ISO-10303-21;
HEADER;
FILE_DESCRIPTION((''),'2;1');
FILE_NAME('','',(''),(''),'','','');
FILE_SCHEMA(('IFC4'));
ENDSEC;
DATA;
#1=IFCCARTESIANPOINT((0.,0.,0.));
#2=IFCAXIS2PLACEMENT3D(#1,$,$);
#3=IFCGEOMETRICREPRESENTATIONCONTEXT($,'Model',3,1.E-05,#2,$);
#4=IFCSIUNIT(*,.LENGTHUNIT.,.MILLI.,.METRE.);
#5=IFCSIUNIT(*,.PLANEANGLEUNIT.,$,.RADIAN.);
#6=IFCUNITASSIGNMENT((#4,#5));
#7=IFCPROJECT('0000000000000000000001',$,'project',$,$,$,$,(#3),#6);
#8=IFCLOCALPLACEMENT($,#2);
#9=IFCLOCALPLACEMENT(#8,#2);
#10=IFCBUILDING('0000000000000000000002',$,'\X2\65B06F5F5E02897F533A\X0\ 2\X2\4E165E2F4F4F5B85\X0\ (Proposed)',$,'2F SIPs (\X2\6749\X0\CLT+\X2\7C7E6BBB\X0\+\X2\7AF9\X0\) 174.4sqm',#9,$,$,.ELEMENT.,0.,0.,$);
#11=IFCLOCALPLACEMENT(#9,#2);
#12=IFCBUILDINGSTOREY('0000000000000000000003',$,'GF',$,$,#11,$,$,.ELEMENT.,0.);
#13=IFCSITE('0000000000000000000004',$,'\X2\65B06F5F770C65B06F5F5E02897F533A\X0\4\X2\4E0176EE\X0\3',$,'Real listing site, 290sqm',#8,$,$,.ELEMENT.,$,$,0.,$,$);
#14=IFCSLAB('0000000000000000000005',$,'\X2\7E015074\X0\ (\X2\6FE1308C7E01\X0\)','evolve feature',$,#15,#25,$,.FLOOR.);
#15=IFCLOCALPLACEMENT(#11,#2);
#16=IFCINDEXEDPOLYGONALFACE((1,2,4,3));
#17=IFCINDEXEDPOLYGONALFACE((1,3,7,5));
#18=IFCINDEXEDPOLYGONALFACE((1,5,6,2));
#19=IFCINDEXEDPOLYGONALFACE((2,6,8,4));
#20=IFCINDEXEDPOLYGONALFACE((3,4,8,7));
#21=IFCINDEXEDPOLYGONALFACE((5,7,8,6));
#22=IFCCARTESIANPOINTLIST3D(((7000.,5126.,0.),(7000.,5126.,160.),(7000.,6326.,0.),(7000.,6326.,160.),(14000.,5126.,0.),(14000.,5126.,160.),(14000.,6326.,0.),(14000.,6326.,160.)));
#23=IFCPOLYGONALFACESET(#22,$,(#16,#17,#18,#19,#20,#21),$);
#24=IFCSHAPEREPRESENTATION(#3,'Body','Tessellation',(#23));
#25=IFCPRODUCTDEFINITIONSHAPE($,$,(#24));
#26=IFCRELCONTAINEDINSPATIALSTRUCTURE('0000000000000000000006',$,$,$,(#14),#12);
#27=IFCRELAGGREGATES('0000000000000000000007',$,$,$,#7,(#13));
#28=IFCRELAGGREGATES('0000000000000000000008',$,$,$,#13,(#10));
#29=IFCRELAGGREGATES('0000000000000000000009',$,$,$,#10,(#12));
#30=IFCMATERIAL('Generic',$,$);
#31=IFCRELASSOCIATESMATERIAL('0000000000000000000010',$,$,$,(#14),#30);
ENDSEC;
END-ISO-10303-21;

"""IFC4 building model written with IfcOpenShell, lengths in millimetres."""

from ifc_helpers import new_model, si_unit, frame, frame_2d, origin, place, context, project, spatial, rectangle, extrude, material, element, save


model = new_model("IFC4")

# Units and contexts
model_context = context("Model", 3, precision=1e-05, world=origin())
ifc_project = project(units=[si_unit("LENGTHUNIT", "METRE", prefix="MILLI"), si_unit("PLANEANGLEUNIT", "RADIAN")], contexts=[model_context])

# Site, building, storey
site_placement = place(None, origin())
site = spatial("IfcSite", under=ifc_project, at=site_placement, Name="新潟県新潟市西区4丁目3", ObjectType="Real listing site, 290sqm", CompositionType="ELEMENT", RefElevation=0.0)
building_placement = place(site_placement, origin())
building = spatial("IfcBuilding", under=site, at=building_placement, Name="新潟市西区 2世帯住宅 (Proposed)", ObjectType="2F SIPs (杉CLT+籾殻+竹) 174.4sqm", CompositionType="ELEMENT", ElevationOfRefHeight=0.0, ElevationOfTerrain=0.0)
storey_placement = place(building_placement, origin())
storey = spatial("IfcBuildingStorey", under=building, at=storey_placement, Name="GF", CompositionType="ELEMENT", Elevation=0.0)

# Slab
ifc_material_1 = material(Name="Generic")
slab_1_placement = place(storey_placement, frame((3500.0, 2563.0, 0.0)))
element("IfcSlab", 1, at=slab_1_placement, inside=storey, material=ifc_material_1, Name="縁側 (濡れ縁)", Description="evolve feature", PredefinedType="FLOOR", context=model_context, shape_type="SweptSolid", body=[
    extrude(rectangle(XDim=7000.0, YDim=1200.0, at=frame_2d((3500.0, 600.0))), frame((3500.0, 2563.0, 0.0)), (0.0, 0.0, 1.0), 160.0),
])

save(model, "model.ifc")
